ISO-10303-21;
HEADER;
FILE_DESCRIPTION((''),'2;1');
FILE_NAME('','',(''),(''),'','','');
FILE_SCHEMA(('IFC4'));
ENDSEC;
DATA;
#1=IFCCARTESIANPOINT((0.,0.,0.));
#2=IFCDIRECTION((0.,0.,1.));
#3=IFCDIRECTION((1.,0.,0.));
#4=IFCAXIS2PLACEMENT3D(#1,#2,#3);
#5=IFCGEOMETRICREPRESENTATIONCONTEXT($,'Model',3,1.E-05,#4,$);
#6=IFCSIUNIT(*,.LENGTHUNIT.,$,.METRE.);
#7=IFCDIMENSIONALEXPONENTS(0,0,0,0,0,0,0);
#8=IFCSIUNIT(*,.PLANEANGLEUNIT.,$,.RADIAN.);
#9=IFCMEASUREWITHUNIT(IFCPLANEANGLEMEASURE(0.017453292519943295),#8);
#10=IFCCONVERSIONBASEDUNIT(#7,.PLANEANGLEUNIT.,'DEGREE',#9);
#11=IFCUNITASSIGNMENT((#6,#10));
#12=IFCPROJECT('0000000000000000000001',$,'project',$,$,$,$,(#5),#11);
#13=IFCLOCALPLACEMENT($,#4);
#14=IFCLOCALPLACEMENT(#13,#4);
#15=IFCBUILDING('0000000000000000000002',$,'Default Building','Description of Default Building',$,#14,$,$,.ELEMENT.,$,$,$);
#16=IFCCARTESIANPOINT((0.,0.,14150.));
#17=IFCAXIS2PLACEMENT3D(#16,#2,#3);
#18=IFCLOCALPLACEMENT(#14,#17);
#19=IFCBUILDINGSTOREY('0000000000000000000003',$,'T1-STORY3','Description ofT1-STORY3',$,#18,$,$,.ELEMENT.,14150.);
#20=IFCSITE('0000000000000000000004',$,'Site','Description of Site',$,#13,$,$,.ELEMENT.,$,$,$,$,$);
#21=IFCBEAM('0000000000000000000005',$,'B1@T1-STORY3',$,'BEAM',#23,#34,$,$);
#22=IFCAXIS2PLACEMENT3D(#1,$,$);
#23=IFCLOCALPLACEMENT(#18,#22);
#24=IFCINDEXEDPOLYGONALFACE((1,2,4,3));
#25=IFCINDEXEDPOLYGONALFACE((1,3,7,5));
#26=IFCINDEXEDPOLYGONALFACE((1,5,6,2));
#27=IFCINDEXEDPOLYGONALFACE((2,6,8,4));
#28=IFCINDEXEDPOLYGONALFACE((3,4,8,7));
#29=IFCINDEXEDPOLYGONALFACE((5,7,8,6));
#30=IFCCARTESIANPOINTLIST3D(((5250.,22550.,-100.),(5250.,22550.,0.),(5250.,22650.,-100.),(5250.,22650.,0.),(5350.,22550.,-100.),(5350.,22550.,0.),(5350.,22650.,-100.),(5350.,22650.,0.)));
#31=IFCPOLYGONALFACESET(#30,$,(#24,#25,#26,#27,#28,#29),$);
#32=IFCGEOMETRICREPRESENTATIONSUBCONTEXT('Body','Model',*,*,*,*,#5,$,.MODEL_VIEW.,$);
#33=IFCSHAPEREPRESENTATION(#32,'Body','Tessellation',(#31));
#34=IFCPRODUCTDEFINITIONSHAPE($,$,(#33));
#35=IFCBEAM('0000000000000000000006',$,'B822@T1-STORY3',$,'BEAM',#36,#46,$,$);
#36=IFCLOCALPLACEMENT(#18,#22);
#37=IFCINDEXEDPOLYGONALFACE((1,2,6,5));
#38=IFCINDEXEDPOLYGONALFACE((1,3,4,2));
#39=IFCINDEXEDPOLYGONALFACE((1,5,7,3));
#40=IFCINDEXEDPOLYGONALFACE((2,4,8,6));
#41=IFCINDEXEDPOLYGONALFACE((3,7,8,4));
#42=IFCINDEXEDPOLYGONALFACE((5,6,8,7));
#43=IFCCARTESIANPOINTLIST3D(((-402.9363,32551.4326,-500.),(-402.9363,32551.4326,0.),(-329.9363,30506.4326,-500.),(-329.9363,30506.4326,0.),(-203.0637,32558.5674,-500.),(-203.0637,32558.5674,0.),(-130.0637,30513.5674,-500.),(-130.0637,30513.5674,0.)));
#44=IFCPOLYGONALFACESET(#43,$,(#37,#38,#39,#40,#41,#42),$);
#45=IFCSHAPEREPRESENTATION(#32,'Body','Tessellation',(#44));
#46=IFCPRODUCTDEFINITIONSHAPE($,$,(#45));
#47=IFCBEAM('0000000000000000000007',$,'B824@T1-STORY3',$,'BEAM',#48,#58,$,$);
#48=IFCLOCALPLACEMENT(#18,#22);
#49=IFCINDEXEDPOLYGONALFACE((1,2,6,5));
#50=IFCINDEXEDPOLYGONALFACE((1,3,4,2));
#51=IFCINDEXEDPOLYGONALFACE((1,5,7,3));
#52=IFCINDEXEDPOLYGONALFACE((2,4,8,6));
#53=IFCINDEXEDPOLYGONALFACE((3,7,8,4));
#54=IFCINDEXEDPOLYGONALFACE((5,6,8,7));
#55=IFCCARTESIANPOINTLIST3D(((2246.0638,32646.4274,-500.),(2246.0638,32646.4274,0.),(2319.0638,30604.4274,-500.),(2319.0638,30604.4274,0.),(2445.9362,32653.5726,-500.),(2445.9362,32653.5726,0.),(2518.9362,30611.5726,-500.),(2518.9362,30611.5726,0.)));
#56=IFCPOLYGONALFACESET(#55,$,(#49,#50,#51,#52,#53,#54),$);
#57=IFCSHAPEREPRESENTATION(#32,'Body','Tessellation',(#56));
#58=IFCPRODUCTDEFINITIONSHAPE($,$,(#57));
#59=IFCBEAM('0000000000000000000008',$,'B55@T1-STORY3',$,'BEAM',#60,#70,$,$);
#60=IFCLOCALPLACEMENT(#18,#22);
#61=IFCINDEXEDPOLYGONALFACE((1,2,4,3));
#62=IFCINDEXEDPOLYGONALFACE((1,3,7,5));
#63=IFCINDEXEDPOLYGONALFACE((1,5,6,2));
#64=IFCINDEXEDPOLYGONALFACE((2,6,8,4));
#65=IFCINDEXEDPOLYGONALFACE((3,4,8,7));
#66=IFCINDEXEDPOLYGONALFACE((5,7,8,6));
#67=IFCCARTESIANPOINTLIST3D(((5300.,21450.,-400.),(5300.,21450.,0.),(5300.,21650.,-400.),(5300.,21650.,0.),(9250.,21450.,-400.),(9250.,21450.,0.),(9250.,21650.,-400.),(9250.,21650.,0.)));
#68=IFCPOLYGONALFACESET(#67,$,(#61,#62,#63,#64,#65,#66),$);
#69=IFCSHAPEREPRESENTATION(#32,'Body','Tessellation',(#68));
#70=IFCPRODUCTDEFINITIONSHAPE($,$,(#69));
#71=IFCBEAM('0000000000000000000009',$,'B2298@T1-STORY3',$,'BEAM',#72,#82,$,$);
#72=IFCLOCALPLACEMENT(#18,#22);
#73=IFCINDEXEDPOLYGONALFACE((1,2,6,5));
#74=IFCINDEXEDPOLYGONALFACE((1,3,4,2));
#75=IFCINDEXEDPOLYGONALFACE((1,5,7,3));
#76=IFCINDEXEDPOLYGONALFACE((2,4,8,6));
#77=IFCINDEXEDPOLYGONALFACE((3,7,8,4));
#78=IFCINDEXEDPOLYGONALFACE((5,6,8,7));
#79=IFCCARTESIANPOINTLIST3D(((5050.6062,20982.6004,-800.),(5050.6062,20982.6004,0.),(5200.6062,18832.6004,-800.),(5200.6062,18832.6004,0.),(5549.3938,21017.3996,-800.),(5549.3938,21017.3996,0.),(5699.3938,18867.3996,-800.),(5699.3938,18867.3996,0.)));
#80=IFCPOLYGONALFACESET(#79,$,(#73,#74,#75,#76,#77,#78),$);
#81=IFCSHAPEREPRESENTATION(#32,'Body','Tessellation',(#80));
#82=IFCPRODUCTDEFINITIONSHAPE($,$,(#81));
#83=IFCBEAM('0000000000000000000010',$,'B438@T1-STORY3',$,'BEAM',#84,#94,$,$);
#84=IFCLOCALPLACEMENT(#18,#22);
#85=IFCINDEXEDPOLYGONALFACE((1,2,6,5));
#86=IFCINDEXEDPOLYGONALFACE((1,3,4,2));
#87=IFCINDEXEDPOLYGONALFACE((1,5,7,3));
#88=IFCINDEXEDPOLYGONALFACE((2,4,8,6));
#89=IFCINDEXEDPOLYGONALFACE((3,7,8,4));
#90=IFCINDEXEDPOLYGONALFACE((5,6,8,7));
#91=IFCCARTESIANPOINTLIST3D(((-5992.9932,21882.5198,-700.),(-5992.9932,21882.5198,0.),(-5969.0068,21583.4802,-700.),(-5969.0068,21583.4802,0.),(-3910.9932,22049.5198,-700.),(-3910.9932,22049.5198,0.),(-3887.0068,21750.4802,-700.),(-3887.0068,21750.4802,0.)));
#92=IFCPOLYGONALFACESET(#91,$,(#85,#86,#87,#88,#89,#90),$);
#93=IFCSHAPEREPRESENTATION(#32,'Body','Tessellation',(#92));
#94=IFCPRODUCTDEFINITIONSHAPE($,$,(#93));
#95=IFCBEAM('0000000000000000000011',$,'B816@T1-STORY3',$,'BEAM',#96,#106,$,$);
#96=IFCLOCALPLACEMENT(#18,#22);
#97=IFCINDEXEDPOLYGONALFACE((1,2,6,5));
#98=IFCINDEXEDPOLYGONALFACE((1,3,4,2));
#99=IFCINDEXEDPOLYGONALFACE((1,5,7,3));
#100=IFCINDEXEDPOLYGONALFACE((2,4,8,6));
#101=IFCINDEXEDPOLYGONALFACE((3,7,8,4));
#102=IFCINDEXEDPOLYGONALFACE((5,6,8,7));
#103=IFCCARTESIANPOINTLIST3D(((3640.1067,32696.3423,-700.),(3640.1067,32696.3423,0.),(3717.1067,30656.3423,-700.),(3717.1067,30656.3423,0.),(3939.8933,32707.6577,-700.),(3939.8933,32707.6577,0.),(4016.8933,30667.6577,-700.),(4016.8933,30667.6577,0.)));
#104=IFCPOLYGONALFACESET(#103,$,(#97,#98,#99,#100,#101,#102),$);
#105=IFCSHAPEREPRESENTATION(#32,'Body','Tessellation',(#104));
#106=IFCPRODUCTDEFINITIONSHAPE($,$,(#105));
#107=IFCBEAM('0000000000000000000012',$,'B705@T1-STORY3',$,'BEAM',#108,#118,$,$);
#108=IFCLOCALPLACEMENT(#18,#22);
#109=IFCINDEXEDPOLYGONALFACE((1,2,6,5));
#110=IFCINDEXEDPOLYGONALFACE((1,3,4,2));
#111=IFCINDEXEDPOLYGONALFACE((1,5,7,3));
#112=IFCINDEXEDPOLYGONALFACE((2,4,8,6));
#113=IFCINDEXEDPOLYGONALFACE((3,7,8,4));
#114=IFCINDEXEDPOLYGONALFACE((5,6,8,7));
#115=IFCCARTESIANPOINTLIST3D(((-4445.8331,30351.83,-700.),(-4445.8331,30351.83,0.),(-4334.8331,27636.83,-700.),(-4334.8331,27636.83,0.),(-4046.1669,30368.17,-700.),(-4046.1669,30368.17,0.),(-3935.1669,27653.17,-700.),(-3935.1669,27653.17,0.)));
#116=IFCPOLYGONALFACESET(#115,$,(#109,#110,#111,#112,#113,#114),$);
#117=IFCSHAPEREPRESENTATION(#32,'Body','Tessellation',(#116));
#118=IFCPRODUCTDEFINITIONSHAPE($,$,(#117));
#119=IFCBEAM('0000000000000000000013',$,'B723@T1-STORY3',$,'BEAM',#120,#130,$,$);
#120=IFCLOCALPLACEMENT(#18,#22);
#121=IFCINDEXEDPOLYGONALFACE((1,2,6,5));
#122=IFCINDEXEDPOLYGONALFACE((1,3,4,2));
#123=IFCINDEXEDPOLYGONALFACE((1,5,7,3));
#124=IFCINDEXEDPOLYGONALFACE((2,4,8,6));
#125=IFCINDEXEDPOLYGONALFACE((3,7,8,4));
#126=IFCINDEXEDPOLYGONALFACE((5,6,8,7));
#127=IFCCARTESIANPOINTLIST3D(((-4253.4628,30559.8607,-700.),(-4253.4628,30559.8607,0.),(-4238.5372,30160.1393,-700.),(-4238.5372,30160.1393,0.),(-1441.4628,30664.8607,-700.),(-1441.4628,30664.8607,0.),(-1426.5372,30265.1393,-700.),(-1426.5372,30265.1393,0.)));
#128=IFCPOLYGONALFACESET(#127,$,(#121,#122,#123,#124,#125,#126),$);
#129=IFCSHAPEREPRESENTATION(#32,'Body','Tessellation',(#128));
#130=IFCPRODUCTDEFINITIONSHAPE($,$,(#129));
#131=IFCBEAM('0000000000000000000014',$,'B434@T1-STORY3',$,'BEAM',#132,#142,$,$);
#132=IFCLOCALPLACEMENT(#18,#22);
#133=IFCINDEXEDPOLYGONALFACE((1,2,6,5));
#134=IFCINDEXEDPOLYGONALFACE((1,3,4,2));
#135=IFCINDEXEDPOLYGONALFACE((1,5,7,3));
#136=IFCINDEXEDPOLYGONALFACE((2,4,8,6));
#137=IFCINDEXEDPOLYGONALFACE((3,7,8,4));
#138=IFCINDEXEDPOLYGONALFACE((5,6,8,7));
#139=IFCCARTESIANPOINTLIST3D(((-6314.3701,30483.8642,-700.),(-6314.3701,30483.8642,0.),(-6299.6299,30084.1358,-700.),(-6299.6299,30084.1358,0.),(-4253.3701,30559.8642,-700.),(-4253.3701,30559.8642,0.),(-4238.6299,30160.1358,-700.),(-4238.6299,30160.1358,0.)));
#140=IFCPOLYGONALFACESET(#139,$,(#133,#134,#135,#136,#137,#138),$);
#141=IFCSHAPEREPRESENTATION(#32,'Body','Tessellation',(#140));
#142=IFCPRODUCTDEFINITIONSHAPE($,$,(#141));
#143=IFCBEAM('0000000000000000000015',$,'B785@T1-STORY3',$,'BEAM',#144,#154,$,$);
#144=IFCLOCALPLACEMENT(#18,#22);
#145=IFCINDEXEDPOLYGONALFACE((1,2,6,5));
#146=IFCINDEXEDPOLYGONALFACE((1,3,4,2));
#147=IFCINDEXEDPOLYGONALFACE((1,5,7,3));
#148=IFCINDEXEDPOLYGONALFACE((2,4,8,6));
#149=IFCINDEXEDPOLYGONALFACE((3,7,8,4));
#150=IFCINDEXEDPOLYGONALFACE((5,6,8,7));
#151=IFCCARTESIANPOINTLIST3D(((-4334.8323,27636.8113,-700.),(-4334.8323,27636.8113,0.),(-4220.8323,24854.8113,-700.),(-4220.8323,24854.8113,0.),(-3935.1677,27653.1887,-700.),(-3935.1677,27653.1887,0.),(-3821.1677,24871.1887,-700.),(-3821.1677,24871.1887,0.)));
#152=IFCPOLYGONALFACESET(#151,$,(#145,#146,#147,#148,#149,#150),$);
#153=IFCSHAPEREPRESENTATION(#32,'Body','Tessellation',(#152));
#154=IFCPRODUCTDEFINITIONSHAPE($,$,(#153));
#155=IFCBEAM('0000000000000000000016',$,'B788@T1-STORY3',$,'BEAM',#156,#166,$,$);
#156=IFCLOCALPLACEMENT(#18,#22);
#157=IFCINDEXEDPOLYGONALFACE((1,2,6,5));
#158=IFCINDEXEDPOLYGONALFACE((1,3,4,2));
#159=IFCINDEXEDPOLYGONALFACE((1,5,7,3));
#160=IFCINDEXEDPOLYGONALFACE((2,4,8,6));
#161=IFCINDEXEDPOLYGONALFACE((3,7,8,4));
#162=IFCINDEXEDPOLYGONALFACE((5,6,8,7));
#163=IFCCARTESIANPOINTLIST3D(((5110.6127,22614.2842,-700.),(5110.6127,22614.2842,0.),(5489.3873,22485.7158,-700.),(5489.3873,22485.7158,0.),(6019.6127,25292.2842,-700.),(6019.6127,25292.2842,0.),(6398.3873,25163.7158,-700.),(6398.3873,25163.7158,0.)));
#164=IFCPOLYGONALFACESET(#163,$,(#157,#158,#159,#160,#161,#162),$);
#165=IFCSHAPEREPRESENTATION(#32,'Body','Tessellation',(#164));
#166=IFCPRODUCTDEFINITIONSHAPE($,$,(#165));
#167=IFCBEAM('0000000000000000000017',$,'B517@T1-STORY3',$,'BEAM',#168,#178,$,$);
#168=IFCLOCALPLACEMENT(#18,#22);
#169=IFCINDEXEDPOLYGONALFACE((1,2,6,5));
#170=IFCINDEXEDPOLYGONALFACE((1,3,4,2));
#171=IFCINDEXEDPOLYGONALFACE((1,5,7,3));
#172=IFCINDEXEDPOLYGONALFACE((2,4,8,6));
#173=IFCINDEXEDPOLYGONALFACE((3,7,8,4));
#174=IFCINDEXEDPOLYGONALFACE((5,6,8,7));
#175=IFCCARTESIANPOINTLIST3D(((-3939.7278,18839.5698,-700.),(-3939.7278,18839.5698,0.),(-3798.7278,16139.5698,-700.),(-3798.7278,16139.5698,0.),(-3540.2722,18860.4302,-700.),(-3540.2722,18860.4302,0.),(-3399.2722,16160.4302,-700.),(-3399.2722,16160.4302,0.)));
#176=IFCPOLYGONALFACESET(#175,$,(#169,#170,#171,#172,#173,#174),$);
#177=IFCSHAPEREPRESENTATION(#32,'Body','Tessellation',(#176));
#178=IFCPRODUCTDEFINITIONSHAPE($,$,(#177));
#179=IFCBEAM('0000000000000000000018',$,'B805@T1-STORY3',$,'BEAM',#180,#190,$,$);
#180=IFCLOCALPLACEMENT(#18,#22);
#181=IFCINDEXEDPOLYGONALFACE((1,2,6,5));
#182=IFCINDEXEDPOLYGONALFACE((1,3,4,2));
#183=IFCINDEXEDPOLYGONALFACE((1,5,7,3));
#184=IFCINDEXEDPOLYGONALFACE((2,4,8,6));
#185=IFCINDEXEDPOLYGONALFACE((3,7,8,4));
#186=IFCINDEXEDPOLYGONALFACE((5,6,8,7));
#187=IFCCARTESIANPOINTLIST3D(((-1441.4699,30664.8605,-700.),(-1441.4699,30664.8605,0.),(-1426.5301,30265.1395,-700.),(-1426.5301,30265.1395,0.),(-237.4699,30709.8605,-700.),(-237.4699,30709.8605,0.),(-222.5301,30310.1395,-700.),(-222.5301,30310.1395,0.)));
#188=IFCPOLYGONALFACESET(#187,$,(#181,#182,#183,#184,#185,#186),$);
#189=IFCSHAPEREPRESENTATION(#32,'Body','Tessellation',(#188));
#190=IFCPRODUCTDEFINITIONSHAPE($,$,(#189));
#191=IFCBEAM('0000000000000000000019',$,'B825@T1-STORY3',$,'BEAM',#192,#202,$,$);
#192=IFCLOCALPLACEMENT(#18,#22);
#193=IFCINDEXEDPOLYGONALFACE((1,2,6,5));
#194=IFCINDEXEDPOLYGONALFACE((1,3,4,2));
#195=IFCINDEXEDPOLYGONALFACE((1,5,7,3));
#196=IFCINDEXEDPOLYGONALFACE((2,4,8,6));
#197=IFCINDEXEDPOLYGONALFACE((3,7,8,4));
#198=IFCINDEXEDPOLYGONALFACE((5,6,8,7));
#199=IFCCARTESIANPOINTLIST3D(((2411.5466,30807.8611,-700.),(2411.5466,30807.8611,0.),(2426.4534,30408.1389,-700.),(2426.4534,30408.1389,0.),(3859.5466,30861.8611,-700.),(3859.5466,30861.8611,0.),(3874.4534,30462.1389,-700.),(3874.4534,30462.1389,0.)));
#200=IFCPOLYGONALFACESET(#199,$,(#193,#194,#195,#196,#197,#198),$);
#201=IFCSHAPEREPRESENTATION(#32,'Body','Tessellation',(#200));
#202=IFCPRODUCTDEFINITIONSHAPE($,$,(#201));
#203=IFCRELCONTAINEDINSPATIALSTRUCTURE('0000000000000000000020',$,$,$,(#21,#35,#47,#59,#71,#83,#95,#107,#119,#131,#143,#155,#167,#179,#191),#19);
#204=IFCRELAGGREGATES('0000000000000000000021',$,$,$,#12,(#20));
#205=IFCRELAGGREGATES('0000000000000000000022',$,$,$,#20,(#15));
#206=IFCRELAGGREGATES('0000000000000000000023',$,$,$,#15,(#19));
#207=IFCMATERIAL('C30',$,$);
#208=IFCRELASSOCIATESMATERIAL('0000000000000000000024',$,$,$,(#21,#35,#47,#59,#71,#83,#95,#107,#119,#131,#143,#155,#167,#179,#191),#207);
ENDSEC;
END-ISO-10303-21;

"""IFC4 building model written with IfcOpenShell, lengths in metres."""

from ifc_helpers import new_model, entity, si_unit, converted_unit, frame, origin_with_axes, place, context, subcontext, project, spatial, rectangle, extrude, material, element, save


model = new_model("IFC4")

# Units and contexts
model_context = context("Model", 3, precision=1e-05, world=origin_with_axes())
body_context = subcontext(model_context, "Body", "Model", "MODEL_VIEW")
ifc_project = project(units=[si_unit("LENGTHUNIT", "METRE"), converted_unit("PLANEANGLEUNIT", "DEGREE", entity("IfcPlaneAngleMeasure", 0.017453292519943295), si_unit("PLANEANGLEUNIT", "RADIAN"), dimensions=[0, 0, 0, 0, 0, 0, 0])], contexts=[model_context])

# Site, building, storey
site_placement = place(None, origin_with_axes())
site = spatial("IfcSite", under=ifc_project, at=site_placement, Name="Site", Description="Description of Site", CompositionType="ELEMENT")
building_placement = place(site_placement, origin_with_axes())
building = spatial("IfcBuilding", under=site, at=building_placement, Name="Default Building", Description="Description of Default Building", CompositionType="ELEMENT")
storey_placement = place(building_placement, frame((0.0, 0.0, 14150.0), z_axis=(0.0, 0.0, 1.0), x_axis=(1.0, 0.0, 0.0)))
storey = spatial("IfcBuildingStorey", under=building, at=storey_placement, Name="T1-STORY3", Description="Description ofT1-STORY3", CompositionType="ELEMENT", Elevation=14150.0)

# Beams
ifc_material_1 = material(Name="C30")
beam_1_placement = place(storey_placement, frame((5300.0, 22550.0, -50.0), z_axis=(0.0, 1.0, 0.0), x_axis=(-1.0, 0.0, 0.0)))
element("IfcBeam", 1, at=beam_1_placement, inside=storey, material=ifc_material_1, Name="B1@T1-STORY3", ObjectType="BEAM", context=body_context, shape_type="SweptSolid", body=[
    extrude(rectangle(XDim=100.0, YDim=100.0), origin_with_axes(), (0.0, 0.0, 1.0), 100.0),
])
beam_2_placement = place(storey_placement, frame((-303.0, 32555.0, -250.0), z_axis=(0.035674, -0.999363, 0.0), x_axis=(0.999363, 0.035674, 0.0)))
element("IfcBeam", 2, at=beam_2_placement, inside=storey, material=ifc_material_1, Name="B822@T1-STORY3", ObjectType="BEAM", context=body_context, shape_type="SweptSolid", body=[
    extrude(rectangle(XDim=200.0, YDim=500.0), origin_with_axes(), (0.0, 0.0, 1.0), 2046.3025),
])
beam_3_placement = place(storey_placement, frame((2346.0, 32650.0, -250.0), z_axis=(0.035726, -0.999362, 0.0), x_axis=(0.999362, 0.035726, 0.0)))
element("IfcBeam", 3, at=beam_3_placement, inside=storey, material=ifc_material_1, Name="B824@T1-STORY3", ObjectType="BEAM", context=body_context, shape_type="SweptSolid", body=[
    extrude(rectangle(XDim=200.0, YDim=500.0), origin_with_axes(), (0.0, 0.0, 1.0), 2043.3044),
])
beam_4_placement = place(storey_placement, frame((5300.0, 21550.0, -200.0), z_axis=(1.0, 0.0, 0.0), x_axis=(0.0, 1.0, 0.0)))
element("IfcBeam", 4, at=beam_4_placement, inside=storey, material=ifc_material_1, Name="B55@T1-STORY3", ObjectType="BEAM", context=body_context, shape_type="SweptSolid", body=[
    extrude(rectangle(XDim=200.0, YDim=400.0), origin_with_axes(), (0.0, 0.0, 1.0), 3950.0),
])
beam_5_placement = place(storey_placement, frame((5300.0, 21000.0, -400.0), z_axis=(0.069598, -0.997575, 0.0), x_axis=(0.997575, 0.069598, 0.0)))
element("IfcBeam", 5, at=beam_5_placement, inside=storey, material=ifc_material_1, Name="B2298@T1-STORY3", ObjectType="BEAM", context=body_context, shape_type="SweptSolid", body=[
    extrude(rectangle(XDim=500.0, YDim=800.0), origin_with_axes(), (0.0, 0.0, 1.0), 2155.2262),
])
beam_6_placement = place(storey_placement, frame((-5981.0, 21733.0, -350.0), z_axis=(0.996799, 0.079955, 0.0), x_axis=(-0.079955, 0.996799, 0.0)))
element("IfcBeam", 6, at=beam_6_placement, inside=storey, material=ifc_material_1, Name="B438@T1-STORY3", ObjectType="BEAM", context=body_context, shape_type="SweptSolid", body=[
    extrude(rectangle(XDim=300.0, YDim=700.0), origin_with_axes(), (0.0, 0.0, 1.0), 2088.6869),
])
beam_7_placement = place(storey_placement, frame((3790.0, 32702.0, -350.0), z_axis=(0.037718, -0.999288, 0.0), x_axis=(0.999288, 0.037718, 0.0)))
element("IfcBeam", 7, at=beam_7_placement, inside=storey, material=ifc_material_1, Name="B816@T1-STORY3", ObjectType="BEAM", context=body_context, shape_type="SweptSolid", body=[
    extrude(rectangle(XDim=300.0, YDim=700.0), origin_with_axes(), (0.0, 0.0, 1.0), 2041.4527),
])
beam_8_placement = place(storey_placement, frame((-4246.0, 30360.0, -350.0), z_axis=(0.04085, -0.999165, 0.0), x_axis=(0.999165, 0.04085, 0.0)))
element("IfcBeam", 8, at=beam_8_placement, inside=storey, material=ifc_material_1, Name="B705@T1-STORY3", ObjectType="BEAM", context=body_context, shape_type="SweptSolid", body=[
    extrude(rectangle(XDim=400.0, YDim=700.0), origin_with_axes(), (0.0, 0.0, 1.0), 2717.2681),
])
beam_9_placement = place(storey_placement, frame((-4246.0, 30360.0, -350.0), z_axis=(0.999304, 0.037314, 0.0), x_axis=(-0.037314, 0.999304, 0.0)))
element("IfcBeam", 9, at=beam_9_placement, inside=storey, material=ifc_material_1, Name="B723@T1-STORY3", ObjectType="BEAM", context=body_context, shape_type="SweptSolid", body=[
    extrude(rectangle(XDim=400.0, YDim=700.0), origin_with_axes(), (0.0, 0.0, 1.0), 2813.9597),
])
beam_10_placement = place(storey_placement, frame((-6307.0, 30284.0, -350.0), z_axis=(0.999321, 0.03685, 0.0), x_axis=(-0.03685, 0.999321, 0.0)))
element("IfcBeam", 10, at=beam_10_placement, inside=storey, material=ifc_material_1, Name="B434@T1-STORY3", ObjectType="BEAM", context=body_context, shape_type="SweptSolid", body=[
    extrude(rectangle(XDim=400.0, YDim=700.0), origin_with_axes(), (0.0, 0.0, 1.0), 2062.4008),
])
beam_11_placement = place(storey_placement, frame((-4135.0, 27645.0, -350.0), z_axis=(0.040943, -0.999161, 0.0), x_axis=(0.999161, 0.040943, 0.0)))
element("IfcBeam", 11, at=beam_11_placement, inside=storey, material=ifc_material_1, Name="B785@T1-STORY3", ObjectType="BEAM", context=body_context, shape_type="SweptSolid", body=[
    extrude(rectangle(XDim=400.0, YDim=700.0), origin_with_axes(), (0.0, 0.0, 1.0), 2784.3347),
])
beam_12_placement = place(storey_placement, frame((5300.0, 22550.0, -350.0), z_axis=(0.321421, 0.946936, 0.0), x_axis=(-0.946936, 0.321421, 0.0)))
element("IfcBeam", 12, at=beam_12_placement, inside=storey, material=ifc_material_1, Name="B788@T1-STORY3", ObjectType="BEAM", context=body_context, shape_type="SweptSolid", body=[
    extrude(rectangle(XDim=400.0, YDim=700.0), origin_with_axes(), (0.0, 0.0, 1.0), 2828.0674),
])
beam_13_placement = place(storey_placement, frame((-3740.0, 18850.0, -350.0), z_axis=(0.052151, -0.998639, 0.0), x_axis=(0.998639, 0.052151, 0.0)))
element("IfcBeam", 13, at=beam_13_placement, inside=storey, material=ifc_material_1, Name="B517@T1-STORY3", ObjectType="BEAM", context=body_context, shape_type="SweptSolid", body=[
    extrude(rectangle(XDim=400.0, YDim=700.0), origin_with_axes(), (0.0, 0.0, 1.0), 2703.6792),
])
beam_14_placement = place(storey_placement, frame((-1434.0, 30465.0, -350.0), z_axis=(0.999302, 0.037349, 0.0), x_axis=(-0.037349, 0.999302, 0.0)))
element("IfcBeam", 14, at=beam_14_placement, inside=storey, material=ifc_material_1, Name="B805@T1-STORY3", ObjectType="BEAM", context=body_context, shape_type="SweptSolid", body=[
    extrude(rectangle(XDim=400.0, YDim=700.0), origin_with_axes(), (0.0, 0.0, 1.0), 1204.8407),
])
beam_15_placement = place(storey_placement, frame((2419.0, 30608.0, -350.0), z_axis=(0.999305, 0.037267, 0.0), x_axis=(-0.037267, 0.999305, 0.0)))
element("IfcBeam", 15, at=beam_15_placement, inside=storey, material=ifc_material_1, Name="B825@T1-STORY3", ObjectType="BEAM", context=body_context, shape_type="SweptSolid", body=[
    extrude(rectangle(XDim=400.0, YDim=700.0), origin_with_axes(), (0.0, 0.0, 1.0), 1449.0066),
])

save(model, "model.ifc")
